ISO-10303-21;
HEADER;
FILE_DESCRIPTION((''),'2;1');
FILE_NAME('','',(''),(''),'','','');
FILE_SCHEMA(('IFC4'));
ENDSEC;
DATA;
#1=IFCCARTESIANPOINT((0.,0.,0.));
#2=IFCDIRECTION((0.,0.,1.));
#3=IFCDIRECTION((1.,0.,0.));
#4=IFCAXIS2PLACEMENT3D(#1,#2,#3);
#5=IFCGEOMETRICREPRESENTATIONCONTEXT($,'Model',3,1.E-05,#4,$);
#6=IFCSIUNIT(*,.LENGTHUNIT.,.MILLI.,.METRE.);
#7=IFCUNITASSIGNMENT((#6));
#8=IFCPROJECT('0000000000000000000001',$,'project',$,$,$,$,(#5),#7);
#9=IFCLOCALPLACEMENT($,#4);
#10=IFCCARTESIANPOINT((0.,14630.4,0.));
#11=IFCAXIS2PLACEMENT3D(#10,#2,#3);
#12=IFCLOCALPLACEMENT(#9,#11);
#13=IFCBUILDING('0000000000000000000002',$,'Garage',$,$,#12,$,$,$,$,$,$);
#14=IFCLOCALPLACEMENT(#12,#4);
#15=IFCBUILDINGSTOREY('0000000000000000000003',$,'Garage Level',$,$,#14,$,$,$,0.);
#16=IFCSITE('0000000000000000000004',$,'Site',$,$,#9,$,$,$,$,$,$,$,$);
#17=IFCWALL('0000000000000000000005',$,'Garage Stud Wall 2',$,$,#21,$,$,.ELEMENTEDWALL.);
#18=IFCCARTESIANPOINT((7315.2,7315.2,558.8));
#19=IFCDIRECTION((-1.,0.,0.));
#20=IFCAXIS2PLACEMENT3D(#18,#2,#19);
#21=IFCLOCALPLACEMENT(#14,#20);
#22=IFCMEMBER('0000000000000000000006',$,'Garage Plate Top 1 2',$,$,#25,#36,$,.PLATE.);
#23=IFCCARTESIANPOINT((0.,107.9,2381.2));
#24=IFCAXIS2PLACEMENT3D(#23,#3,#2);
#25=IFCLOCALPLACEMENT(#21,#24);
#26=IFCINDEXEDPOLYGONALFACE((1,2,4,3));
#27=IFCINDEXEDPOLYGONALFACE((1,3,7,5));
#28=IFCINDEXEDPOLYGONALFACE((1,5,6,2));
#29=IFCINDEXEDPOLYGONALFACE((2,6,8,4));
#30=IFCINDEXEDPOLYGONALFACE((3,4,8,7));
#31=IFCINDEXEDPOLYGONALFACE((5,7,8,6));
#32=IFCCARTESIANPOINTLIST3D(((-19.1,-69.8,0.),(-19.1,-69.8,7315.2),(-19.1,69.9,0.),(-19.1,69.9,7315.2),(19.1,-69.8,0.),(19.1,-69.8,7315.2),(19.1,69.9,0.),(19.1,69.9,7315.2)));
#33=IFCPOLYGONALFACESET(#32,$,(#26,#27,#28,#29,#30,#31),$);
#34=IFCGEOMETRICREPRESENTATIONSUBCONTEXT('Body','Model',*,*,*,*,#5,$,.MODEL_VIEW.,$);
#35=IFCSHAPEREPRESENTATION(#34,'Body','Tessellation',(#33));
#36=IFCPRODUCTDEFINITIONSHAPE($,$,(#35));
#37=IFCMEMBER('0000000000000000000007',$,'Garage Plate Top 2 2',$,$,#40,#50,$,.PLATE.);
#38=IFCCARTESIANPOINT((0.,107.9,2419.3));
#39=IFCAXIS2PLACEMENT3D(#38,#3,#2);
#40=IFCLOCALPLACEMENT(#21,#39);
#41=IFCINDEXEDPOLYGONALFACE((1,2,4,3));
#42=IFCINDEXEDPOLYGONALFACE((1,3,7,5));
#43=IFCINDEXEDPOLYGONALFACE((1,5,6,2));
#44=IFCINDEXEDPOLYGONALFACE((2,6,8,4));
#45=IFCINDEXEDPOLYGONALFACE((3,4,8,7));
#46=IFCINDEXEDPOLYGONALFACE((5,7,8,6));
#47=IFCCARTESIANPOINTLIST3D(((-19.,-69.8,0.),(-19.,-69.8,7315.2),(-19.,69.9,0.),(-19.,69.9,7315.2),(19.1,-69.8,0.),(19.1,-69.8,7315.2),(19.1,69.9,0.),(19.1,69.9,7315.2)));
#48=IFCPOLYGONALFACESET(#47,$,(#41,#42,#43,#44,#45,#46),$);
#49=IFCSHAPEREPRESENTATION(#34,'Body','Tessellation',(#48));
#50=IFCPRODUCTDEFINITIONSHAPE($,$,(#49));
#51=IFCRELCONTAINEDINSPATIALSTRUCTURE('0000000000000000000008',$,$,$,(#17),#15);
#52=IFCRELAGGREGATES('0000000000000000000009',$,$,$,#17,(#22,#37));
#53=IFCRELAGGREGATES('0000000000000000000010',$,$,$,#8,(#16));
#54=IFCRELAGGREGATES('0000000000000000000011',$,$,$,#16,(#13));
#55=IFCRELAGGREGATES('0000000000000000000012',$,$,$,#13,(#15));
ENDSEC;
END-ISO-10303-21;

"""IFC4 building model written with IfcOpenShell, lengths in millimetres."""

from ifc_helpers import new_model, si_unit, frame, origin_with_axes, origin_2d, place, context, subcontext, project, spatial, rectangle, extrude, element, aggregate, save


model = new_model("IFC4")

# Units and contexts
model_context = context("Model", 3, precision=1e-05, world=origin_with_axes())
body_context = subcontext(model_context, "Body", "Model", "MODEL_VIEW")
ifc_project = project(units=[si_unit("LENGTHUNIT", "METRE", prefix="MILLI")], contexts=[model_context])

# Site, building, storey
site_placement = place(None, origin_with_axes())
site = spatial("IfcSite", under=ifc_project, at=site_placement, Name="Site")
building_placement = place(site_placement, frame((0.0, 14630.4, 0.0), z_axis=(0.0, 0.0, 1.0), x_axis=(1.0, 0.0, 0.0)))
building = spatial("IfcBuilding", under=site, at=building_placement, Name="Garage")
storey_placement = place(building_placement, origin_with_axes())
storey = spatial("IfcBuildingStorey", under=building, at=storey_placement, Name="Garage Level", Elevation=0.0)

# Wall, members
wall_1_placement = place(storey_placement, frame((7315.2, 7315.2, 558.8), z_axis=(0.0, 0.0, 1.0), x_axis=(-1.0, 0.0, 0.0)))
wall_1 = element("IfcWall", 1, at=wall_1_placement, inside=storey, Name="Garage Stud Wall 2", PredefinedType="ELEMENTEDWALL")
member_1_placement = place(wall_1_placement, frame((0.0, 107.9, 2381.2), z_axis=(1.0, 0.0, 0.0), x_axis=(0.0, 0.0, 1.0)))
member_1 = element("IfcMember", 2, at=member_1_placement, Name="Garage Plate Top 1 2", PredefinedType="PLATE", context=body_context, shape_type="SweptSolid", body=[
    extrude(rectangle(XDim=38.1, YDim=139.7, at=origin_2d()), origin_with_axes(), (0.0, 0.0, 1.0), 7315.2),
])
member_2_placement = place(wall_1_placement, frame((0.0, 107.9, 2419.3), z_axis=(1.0, 0.0, 0.0), x_axis=(0.0, 0.0, 1.0)))
member_2 = element("IfcMember", 3, at=member_2_placement, Name="Garage Plate Top 2 2", PredefinedType="PLATE", context=body_context, shape_type="SweptSolid", body=[
    extrude(rectangle(XDim=38.1, YDim=139.7, at=origin_2d()), origin_with_axes(), (0.0, 0.0, 1.0), 7315.2),
])
aggregate(wall_1, [member_1, member_2])

save(model, "model.ifc")
